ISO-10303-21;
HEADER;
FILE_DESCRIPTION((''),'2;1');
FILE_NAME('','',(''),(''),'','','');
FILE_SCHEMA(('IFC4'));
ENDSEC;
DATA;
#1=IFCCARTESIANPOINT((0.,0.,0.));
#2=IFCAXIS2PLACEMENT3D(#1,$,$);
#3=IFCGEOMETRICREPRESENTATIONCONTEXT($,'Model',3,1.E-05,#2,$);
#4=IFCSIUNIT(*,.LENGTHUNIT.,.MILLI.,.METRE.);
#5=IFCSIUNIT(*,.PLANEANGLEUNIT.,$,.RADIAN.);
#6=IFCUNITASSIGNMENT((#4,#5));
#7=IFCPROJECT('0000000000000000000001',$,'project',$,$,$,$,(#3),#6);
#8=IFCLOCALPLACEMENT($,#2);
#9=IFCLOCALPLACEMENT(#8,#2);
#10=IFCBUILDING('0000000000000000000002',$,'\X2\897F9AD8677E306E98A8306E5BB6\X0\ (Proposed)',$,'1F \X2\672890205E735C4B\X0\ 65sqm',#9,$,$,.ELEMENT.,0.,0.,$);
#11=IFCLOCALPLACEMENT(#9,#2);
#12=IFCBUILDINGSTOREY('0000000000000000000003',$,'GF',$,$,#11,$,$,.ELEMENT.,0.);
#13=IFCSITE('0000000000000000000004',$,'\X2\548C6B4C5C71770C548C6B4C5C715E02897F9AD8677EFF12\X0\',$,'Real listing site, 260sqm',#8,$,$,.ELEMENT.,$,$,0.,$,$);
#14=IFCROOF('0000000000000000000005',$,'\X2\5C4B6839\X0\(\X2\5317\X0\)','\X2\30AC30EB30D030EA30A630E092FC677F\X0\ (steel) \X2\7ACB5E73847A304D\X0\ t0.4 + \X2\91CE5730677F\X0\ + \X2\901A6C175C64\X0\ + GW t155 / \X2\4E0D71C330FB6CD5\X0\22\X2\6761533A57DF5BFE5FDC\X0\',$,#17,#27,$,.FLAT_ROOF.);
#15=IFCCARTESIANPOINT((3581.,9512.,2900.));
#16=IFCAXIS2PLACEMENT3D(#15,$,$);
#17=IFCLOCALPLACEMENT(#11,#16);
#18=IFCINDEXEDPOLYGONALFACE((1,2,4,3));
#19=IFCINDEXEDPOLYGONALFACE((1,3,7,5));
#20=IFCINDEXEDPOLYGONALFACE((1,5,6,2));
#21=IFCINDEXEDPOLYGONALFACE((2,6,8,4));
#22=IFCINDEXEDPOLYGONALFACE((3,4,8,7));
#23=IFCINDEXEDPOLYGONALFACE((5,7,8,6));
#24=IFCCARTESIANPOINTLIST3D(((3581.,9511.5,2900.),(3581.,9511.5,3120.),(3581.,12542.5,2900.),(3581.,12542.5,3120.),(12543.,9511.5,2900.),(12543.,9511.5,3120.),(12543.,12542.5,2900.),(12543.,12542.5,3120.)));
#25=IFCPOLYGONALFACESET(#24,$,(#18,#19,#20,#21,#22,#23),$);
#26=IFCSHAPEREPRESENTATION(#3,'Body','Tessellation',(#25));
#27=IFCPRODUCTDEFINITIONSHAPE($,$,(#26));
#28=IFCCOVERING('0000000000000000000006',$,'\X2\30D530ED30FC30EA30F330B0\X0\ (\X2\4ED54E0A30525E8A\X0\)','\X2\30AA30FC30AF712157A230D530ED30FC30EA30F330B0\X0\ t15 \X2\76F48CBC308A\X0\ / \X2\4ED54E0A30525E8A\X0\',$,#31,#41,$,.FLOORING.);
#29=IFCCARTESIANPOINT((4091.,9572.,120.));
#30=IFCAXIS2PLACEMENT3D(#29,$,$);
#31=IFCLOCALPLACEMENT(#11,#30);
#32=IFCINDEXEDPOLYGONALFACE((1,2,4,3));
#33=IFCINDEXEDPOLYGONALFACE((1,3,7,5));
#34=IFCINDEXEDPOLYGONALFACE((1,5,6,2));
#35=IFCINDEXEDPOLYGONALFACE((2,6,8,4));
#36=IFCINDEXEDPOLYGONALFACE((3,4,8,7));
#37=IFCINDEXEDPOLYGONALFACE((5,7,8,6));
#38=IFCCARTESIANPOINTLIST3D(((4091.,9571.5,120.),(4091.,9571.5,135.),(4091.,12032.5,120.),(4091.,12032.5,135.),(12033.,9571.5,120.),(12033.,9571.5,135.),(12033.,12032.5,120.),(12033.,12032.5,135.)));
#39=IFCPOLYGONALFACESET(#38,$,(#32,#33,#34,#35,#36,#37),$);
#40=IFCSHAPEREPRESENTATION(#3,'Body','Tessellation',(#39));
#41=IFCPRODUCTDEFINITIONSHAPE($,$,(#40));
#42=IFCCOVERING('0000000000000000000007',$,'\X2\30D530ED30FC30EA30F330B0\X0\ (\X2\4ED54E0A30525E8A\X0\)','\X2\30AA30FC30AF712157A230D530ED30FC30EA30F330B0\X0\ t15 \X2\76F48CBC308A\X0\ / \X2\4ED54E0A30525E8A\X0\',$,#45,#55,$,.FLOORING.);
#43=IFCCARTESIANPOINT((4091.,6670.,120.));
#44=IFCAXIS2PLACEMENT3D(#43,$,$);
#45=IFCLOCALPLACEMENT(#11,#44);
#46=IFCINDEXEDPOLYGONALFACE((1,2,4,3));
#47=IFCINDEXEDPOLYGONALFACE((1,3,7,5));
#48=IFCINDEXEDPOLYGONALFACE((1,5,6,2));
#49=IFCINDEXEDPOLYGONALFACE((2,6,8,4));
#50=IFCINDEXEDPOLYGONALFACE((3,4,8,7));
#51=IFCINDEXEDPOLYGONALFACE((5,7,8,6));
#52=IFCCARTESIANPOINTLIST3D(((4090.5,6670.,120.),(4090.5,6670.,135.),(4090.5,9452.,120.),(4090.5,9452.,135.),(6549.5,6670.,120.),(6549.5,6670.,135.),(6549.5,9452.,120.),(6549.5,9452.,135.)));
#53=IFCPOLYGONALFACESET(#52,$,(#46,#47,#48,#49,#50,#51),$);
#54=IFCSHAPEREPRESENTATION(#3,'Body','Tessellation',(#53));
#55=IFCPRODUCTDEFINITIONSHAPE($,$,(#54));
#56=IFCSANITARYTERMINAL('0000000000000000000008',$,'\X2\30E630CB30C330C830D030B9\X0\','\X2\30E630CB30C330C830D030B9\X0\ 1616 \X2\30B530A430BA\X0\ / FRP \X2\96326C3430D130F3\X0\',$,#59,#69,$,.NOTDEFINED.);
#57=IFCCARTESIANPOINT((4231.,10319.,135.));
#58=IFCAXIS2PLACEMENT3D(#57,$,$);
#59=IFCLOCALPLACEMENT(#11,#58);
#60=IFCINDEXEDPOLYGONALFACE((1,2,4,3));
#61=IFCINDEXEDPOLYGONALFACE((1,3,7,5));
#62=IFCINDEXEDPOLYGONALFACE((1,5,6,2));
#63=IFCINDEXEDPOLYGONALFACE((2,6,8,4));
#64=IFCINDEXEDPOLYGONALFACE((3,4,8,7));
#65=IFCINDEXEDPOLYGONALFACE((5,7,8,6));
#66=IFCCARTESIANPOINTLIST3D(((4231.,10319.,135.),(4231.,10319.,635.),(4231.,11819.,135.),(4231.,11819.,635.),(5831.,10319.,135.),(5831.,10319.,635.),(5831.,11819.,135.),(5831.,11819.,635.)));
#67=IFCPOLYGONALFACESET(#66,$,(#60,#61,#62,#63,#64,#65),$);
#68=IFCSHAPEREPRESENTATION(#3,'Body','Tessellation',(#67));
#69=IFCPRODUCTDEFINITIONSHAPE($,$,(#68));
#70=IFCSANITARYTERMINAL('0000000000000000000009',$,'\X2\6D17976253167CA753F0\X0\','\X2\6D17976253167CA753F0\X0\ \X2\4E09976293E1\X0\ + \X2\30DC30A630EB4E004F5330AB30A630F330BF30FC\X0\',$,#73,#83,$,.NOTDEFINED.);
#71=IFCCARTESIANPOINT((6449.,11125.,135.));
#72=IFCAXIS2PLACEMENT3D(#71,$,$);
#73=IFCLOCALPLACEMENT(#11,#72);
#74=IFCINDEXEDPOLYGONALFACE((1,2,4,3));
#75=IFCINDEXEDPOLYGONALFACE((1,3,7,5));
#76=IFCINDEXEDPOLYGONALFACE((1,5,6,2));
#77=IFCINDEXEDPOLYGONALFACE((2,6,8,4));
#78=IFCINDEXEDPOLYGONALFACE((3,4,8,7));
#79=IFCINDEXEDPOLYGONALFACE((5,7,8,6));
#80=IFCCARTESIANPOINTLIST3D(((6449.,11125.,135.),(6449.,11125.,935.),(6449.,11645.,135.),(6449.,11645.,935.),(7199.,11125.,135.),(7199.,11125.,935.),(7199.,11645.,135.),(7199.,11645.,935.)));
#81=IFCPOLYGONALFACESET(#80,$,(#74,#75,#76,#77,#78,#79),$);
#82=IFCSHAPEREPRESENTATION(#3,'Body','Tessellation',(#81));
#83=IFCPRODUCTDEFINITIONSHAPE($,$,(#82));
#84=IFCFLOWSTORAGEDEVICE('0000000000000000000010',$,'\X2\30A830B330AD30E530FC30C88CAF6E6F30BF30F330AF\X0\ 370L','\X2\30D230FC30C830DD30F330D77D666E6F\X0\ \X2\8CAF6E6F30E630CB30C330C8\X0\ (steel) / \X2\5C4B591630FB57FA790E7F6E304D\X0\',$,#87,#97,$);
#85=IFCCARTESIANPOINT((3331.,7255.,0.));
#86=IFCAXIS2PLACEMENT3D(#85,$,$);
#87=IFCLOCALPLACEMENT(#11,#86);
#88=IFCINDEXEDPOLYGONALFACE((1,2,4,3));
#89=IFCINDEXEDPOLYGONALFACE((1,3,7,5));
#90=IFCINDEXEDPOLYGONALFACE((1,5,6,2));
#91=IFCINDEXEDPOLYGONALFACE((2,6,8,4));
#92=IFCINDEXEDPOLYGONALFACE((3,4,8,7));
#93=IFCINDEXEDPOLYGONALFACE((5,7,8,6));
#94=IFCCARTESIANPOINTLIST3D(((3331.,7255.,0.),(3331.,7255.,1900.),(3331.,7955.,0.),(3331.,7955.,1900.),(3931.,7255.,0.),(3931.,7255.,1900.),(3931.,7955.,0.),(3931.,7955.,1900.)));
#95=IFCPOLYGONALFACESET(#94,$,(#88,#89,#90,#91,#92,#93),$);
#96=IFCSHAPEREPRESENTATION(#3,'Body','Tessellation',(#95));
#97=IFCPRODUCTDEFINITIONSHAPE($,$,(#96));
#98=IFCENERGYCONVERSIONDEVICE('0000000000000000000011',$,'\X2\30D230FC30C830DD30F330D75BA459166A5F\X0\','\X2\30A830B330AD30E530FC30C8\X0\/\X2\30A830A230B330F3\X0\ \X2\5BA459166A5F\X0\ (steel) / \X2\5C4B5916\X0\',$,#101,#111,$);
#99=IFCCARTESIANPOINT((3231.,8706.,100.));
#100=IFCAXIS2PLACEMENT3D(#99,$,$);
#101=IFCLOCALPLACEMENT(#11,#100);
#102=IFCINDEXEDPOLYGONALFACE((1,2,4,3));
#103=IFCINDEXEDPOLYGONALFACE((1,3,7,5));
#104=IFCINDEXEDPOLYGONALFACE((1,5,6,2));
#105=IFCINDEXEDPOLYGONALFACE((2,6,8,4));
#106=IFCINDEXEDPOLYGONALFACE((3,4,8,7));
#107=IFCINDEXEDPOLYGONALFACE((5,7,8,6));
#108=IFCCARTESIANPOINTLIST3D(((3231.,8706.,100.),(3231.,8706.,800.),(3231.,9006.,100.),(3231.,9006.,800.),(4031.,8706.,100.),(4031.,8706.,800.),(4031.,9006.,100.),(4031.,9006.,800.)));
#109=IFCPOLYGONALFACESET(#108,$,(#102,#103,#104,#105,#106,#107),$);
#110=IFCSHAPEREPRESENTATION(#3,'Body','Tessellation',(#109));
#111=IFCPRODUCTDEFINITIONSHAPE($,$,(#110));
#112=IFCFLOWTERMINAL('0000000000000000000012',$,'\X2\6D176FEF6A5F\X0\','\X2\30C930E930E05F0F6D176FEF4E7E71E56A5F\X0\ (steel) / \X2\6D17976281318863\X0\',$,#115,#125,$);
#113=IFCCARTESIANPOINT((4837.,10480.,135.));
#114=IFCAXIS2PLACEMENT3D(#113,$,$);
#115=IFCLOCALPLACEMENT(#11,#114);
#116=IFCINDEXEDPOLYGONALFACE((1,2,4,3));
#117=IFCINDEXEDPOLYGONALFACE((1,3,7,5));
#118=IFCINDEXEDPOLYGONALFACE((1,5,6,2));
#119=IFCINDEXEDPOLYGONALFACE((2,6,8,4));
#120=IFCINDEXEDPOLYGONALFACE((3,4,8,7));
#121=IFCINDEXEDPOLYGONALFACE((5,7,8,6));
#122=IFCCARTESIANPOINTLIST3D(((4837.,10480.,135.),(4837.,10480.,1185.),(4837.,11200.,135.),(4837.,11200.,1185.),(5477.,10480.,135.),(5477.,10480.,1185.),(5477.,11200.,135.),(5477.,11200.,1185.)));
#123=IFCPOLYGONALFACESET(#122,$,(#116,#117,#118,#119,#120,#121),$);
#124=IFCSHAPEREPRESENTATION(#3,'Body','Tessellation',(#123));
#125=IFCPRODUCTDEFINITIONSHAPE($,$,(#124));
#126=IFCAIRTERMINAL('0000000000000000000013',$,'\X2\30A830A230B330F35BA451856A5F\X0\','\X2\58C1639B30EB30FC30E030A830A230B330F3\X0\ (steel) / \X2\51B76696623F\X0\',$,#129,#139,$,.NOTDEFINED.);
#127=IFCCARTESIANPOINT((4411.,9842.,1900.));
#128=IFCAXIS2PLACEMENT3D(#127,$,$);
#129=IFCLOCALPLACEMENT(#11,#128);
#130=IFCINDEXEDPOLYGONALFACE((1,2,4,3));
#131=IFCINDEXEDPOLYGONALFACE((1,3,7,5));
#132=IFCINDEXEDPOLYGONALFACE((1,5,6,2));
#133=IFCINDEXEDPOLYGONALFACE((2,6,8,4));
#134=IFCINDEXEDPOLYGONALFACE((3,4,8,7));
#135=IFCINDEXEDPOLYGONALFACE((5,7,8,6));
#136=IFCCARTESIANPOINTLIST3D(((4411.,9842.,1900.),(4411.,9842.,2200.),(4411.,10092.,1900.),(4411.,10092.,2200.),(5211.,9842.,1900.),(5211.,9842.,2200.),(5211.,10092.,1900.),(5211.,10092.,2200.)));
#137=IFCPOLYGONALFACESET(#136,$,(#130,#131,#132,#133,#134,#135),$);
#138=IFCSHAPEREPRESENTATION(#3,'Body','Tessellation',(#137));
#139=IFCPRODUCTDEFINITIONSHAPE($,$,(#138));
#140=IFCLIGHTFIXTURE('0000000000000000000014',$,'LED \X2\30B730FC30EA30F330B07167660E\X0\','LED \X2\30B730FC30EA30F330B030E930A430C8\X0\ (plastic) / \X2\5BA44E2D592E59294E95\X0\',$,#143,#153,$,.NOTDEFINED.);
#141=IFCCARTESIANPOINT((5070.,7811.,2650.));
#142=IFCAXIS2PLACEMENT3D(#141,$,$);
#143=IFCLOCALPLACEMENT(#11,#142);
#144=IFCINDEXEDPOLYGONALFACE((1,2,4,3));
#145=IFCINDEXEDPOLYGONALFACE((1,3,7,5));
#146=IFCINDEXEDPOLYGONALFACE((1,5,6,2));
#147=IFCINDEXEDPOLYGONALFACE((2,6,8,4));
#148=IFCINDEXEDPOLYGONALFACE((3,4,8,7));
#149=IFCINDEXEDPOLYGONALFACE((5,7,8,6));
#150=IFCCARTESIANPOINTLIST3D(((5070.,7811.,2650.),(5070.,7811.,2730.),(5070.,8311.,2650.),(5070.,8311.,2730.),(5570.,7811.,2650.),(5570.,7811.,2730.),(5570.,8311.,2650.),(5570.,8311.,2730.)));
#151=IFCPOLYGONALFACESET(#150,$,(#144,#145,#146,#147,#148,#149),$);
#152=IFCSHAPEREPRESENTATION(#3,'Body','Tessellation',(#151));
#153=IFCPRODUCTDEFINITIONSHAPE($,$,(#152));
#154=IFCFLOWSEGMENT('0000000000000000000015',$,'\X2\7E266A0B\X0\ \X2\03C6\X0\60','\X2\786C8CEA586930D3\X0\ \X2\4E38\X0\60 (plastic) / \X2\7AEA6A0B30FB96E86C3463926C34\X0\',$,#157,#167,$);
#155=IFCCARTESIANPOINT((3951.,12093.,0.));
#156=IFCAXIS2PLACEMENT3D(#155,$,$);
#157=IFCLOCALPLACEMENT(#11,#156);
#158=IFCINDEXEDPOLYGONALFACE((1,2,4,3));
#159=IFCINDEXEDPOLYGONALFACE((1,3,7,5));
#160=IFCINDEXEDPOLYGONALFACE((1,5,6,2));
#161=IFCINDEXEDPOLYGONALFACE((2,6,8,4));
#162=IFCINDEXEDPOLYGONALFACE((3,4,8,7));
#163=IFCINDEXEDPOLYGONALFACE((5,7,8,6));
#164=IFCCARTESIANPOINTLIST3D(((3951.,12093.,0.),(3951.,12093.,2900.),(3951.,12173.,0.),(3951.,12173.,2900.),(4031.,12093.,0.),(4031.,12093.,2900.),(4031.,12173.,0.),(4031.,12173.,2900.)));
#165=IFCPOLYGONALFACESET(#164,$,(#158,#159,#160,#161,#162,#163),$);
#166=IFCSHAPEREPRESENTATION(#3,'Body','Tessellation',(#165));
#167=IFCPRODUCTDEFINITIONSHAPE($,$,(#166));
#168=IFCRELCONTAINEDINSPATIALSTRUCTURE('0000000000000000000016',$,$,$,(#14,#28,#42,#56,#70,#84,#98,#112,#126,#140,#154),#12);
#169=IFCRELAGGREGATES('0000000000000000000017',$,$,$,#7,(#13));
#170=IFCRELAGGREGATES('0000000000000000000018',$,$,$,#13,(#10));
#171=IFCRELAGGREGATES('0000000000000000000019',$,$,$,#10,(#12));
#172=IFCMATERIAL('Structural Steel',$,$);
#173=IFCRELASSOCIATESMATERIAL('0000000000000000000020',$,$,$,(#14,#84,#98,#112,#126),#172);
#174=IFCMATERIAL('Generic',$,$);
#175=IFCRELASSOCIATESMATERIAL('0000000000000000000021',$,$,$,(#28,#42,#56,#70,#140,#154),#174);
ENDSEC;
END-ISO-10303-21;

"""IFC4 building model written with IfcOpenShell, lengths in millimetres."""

from ifc_helpers import new_model, si_unit, frame, frame_2d, origin, place, context, project, spatial, rectangle, extrude, material, element, save


model = new_model("IFC4")

# Units and contexts
model_context = context("Model", 3, precision=1e-05, world=origin())
ifc_project = project(units=[si_unit("LENGTHUNIT", "METRE", prefix="MILLI"), si_unit("PLANEANGLEUNIT", "RADIAN")], contexts=[model_context])

# Site, building, storey
site_placement = place(None, origin())
site = spatial("IfcSite", under=ifc_project, at=site_placement, Name="和歌山県和歌山市西高松２", ObjectType="Real listing site, 260sqm", CompositionType="ELEMENT", RefElevation=0.0)
building_placement = place(site_placement, origin())
building = spatial("IfcBuilding", under=site, at=building_placement, Name="西高松の風の家 (Proposed)", ObjectType="1F 木造平屋 65sqm", CompositionType="ELEMENT", ElevationOfRefHeight=0.0, ElevationOfTerrain=0.0)
storey_placement = place(building_placement, origin())
storey = spatial("IfcBuildingStorey", under=building, at=storey_placement, Name="GF", CompositionType="ELEMENT", Elevation=0.0)

# Roof
ifc_material_1 = material(Name="Structural Steel")
roof_placement = place(storey_placement, frame((3581.0, 9512.0, 2900.0)))
element("IfcRoof", 1, at=roof_placement, inside=storey, material=ifc_material_1, Name="屋根(北)", Description="ガルバリウム鋼板 (steel) 立平葺き t0.4 + 野地板 + 通気層 + GW t155 / 不燃・法22条区域対応", PredefinedType="FLAT_ROOF", context=model_context, shape_type="SweptSolid", body=[
    extrude(rectangle(XDim=8962.0, YDim=3031.0, at=frame_2d((4481.0, 1515.0))), frame((3581.0, 9512.0, 2900.0)), (0.0, 0.0, 1.0), 220.0),
])

# Coverings
ifc_material_2 = material(Name="Generic")
covering_1_placement = place(storey_placement, frame((4091.0, 9572.0, 120.0)))
element("IfcCovering", 2, at=covering_1_placement, inside=storey, material=ifc_material_2, Name="フローリング (仕上げ床)", Description="オーク無垢フローリング t15 直貼り / 仕上げ床", PredefinedType="FLOORING", context=model_context, shape_type="SweptSolid", body=[
    extrude(rectangle(XDim=7942.0, YDim=2461.0, at=frame_2d((3971.0, 1230.0))), frame((4091.0, 9572.0, 120.0)), (0.0, 0.0, 1.0), 15.0),
])
covering_2_placement = place(storey_placement, frame((4091.0, 6670.0, 120.0)))
element("IfcCovering", 3, at=covering_2_placement, inside=storey, material=ifc_material_2, Name="フローリング (仕上げ床)", Description="オーク無垢フローリング t15 直貼り / 仕上げ床", PredefinedType="FLOORING", context=model_context, shape_type="SweptSolid", body=[
    extrude(rectangle(XDim=2459.0, YDim=2782.0, at=frame_2d((1229.0, 1391.0))), frame((4091.0, 6670.0, 120.0)), (0.0, 0.0, 1.0), 15.0),
])

# Sanitary terminals
sanitary_terminal_1_placement = place(storey_placement, frame((4231.0, 10319.0, 135.0)))
element("IfcSanitaryTerminal", 4, at=sanitary_terminal_1_placement, inside=storey, material=ifc_material_2, Name="ユニットバス", Description="ユニットバス 1616 サイズ / FRP 防水パン", PredefinedType="NOTDEFINED", context=model_context, shape_type="SweptSolid", body=[
    extrude(rectangle(XDim=1600.0, YDim=1500.0, at=frame_2d((800.0, 750.0))), frame((4231.0, 10319.0, 135.0)), (0.0, 0.0, 1.0), 500.0),
])
sanitary_terminal_2_placement = place(storey_placement, frame((6449.0, 11125.0, 135.0)))
element("IfcSanitaryTerminal", 5, at=sanitary_terminal_2_placement, inside=storey, material=ifc_material_2, Name="洗面化粧台", Description="洗面化粧台 三面鏡 + ボウル一体カウンター", PredefinedType="NOTDEFINED", context=model_context, shape_type="SweptSolid", body=[
    extrude(rectangle(XDim=750.0, YDim=520.0, at=frame_2d((375.0, 260.0))), frame((6449.0, 11125.0, 135.0)), (0.0, 0.0, 1.0), 800.0),
])

# Flow storage device
flow_storage_device_placement = place(storey_placement, frame((3331.0, 7255.0, 0.0)))
element("IfcFlowStorageDevice", 6, at=flow_storage_device_placement, inside=storey, material=ifc_material_1, Name="エコキュート貯湯タンク 370L", Description="ヒートポンプ給湯 貯湯ユニット (steel) / 屋外・基礎置き", context=model_context, shape_type="SweptSolid", body=[
    extrude(rectangle(XDim=600.0, YDim=700.0, at=frame_2d((300.0, 350.0))), frame((3331.0, 7255.0, 0.0)), (0.0, 0.0, 1.0), 1900.0),
])

# Energy conversion device
energy_conversion_device_placement = place(storey_placement, frame((3231.0, 8706.0, 100.0)))
element("IfcEnergyConversionDevice", 7, at=energy_conversion_device_placement, inside=storey, material=ifc_material_1, Name="ヒートポンプ室外機", Description="エコキュート/エアコン 室外機 (steel) / 屋外", context=model_context, shape_type="SweptSolid", body=[
    extrude(rectangle(XDim=800.0, YDim=300.0, at=frame_2d((400.0, 150.0))), frame((3231.0, 8706.0, 100.0)), (0.0, 0.0, 1.0), 700.0),
])

# Flow terminal
flow_terminal_placement = place(storey_placement, frame((4837.0, 10480.0, 135.0)))
element("IfcFlowTerminal", 8, at=flow_terminal_placement, inside=storey, material=ifc_material_1, Name="洗濯機", Description="ドラム式洗濯乾燥機 (steel) / 洗面脱衣", context=model_context, shape_type="SweptSolid", body=[
    extrude(rectangle(XDim=640.0, YDim=720.0, at=frame_2d((320.0, 360.0))), frame((4837.0, 10480.0, 135.0)), (0.0, 0.0, 1.0), 1050.0),
])

# Air terminal
air_terminal_placement = place(storey_placement, frame((4411.0, 9842.0, 1900.0)))
element("IfcAirTerminal", 9, at=air_terminal_placement, inside=storey, material=ifc_material_1, Name="エアコン室内機", Description="壁掛ルームエアコン (steel) / 冷暖房", PredefinedType="NOTDEFINED", context=model_context, shape_type="SweptSolid", body=[
    extrude(rectangle(XDim=800.0, YDim=250.0, at=frame_2d((400.0, 125.0))), frame((4411.0, 9842.0, 1900.0)), (0.0, 0.0, 1.0), 300.0),
])

# Light fixture
light_fixture_placement = place(storey_placement, frame((5070.0, 7811.0, 2650.0)))
element("IfcLightFixture", 10, at=light_fixture_placement, inside=storey, material=ifc_material_2, Name="LED シーリング照明", Description="LED シーリングライト (plastic) / 室中央天井", PredefinedType="NOTDEFINED", context=model_context, shape_type="SweptSolid", body=[
    extrude(rectangle(XDim=500.0, YDim=500.0, at=frame_2d((250.0, 250.0))), frame((5070.0, 7811.0, 2650.0)), (0.0, 0.0, 1.0), 80.0),
])

# Flow segment
flow_segment_1_placement = place(storey_placement, frame((3951.0, 12093.0, 0.0)))
element("IfcFlowSegment", 11, at=flow_segment_1_placement, inside=storey, material=ifc_material_2, Name="縦樋 φ60", Description="硬質塩ビ 丸60 (plastic) / 竪樋・雨水排水", context=model_context, shape_type="SweptSolid", body=[
    extrude(rectangle(XDim=80.0, YDim=80.0, at=frame_2d((40.0, 40.0))), frame((3951.0, 12093.0, 0.0)), (0.0, 0.0, 1.0), 2900.0),
])

save(model, "model.ifc")
